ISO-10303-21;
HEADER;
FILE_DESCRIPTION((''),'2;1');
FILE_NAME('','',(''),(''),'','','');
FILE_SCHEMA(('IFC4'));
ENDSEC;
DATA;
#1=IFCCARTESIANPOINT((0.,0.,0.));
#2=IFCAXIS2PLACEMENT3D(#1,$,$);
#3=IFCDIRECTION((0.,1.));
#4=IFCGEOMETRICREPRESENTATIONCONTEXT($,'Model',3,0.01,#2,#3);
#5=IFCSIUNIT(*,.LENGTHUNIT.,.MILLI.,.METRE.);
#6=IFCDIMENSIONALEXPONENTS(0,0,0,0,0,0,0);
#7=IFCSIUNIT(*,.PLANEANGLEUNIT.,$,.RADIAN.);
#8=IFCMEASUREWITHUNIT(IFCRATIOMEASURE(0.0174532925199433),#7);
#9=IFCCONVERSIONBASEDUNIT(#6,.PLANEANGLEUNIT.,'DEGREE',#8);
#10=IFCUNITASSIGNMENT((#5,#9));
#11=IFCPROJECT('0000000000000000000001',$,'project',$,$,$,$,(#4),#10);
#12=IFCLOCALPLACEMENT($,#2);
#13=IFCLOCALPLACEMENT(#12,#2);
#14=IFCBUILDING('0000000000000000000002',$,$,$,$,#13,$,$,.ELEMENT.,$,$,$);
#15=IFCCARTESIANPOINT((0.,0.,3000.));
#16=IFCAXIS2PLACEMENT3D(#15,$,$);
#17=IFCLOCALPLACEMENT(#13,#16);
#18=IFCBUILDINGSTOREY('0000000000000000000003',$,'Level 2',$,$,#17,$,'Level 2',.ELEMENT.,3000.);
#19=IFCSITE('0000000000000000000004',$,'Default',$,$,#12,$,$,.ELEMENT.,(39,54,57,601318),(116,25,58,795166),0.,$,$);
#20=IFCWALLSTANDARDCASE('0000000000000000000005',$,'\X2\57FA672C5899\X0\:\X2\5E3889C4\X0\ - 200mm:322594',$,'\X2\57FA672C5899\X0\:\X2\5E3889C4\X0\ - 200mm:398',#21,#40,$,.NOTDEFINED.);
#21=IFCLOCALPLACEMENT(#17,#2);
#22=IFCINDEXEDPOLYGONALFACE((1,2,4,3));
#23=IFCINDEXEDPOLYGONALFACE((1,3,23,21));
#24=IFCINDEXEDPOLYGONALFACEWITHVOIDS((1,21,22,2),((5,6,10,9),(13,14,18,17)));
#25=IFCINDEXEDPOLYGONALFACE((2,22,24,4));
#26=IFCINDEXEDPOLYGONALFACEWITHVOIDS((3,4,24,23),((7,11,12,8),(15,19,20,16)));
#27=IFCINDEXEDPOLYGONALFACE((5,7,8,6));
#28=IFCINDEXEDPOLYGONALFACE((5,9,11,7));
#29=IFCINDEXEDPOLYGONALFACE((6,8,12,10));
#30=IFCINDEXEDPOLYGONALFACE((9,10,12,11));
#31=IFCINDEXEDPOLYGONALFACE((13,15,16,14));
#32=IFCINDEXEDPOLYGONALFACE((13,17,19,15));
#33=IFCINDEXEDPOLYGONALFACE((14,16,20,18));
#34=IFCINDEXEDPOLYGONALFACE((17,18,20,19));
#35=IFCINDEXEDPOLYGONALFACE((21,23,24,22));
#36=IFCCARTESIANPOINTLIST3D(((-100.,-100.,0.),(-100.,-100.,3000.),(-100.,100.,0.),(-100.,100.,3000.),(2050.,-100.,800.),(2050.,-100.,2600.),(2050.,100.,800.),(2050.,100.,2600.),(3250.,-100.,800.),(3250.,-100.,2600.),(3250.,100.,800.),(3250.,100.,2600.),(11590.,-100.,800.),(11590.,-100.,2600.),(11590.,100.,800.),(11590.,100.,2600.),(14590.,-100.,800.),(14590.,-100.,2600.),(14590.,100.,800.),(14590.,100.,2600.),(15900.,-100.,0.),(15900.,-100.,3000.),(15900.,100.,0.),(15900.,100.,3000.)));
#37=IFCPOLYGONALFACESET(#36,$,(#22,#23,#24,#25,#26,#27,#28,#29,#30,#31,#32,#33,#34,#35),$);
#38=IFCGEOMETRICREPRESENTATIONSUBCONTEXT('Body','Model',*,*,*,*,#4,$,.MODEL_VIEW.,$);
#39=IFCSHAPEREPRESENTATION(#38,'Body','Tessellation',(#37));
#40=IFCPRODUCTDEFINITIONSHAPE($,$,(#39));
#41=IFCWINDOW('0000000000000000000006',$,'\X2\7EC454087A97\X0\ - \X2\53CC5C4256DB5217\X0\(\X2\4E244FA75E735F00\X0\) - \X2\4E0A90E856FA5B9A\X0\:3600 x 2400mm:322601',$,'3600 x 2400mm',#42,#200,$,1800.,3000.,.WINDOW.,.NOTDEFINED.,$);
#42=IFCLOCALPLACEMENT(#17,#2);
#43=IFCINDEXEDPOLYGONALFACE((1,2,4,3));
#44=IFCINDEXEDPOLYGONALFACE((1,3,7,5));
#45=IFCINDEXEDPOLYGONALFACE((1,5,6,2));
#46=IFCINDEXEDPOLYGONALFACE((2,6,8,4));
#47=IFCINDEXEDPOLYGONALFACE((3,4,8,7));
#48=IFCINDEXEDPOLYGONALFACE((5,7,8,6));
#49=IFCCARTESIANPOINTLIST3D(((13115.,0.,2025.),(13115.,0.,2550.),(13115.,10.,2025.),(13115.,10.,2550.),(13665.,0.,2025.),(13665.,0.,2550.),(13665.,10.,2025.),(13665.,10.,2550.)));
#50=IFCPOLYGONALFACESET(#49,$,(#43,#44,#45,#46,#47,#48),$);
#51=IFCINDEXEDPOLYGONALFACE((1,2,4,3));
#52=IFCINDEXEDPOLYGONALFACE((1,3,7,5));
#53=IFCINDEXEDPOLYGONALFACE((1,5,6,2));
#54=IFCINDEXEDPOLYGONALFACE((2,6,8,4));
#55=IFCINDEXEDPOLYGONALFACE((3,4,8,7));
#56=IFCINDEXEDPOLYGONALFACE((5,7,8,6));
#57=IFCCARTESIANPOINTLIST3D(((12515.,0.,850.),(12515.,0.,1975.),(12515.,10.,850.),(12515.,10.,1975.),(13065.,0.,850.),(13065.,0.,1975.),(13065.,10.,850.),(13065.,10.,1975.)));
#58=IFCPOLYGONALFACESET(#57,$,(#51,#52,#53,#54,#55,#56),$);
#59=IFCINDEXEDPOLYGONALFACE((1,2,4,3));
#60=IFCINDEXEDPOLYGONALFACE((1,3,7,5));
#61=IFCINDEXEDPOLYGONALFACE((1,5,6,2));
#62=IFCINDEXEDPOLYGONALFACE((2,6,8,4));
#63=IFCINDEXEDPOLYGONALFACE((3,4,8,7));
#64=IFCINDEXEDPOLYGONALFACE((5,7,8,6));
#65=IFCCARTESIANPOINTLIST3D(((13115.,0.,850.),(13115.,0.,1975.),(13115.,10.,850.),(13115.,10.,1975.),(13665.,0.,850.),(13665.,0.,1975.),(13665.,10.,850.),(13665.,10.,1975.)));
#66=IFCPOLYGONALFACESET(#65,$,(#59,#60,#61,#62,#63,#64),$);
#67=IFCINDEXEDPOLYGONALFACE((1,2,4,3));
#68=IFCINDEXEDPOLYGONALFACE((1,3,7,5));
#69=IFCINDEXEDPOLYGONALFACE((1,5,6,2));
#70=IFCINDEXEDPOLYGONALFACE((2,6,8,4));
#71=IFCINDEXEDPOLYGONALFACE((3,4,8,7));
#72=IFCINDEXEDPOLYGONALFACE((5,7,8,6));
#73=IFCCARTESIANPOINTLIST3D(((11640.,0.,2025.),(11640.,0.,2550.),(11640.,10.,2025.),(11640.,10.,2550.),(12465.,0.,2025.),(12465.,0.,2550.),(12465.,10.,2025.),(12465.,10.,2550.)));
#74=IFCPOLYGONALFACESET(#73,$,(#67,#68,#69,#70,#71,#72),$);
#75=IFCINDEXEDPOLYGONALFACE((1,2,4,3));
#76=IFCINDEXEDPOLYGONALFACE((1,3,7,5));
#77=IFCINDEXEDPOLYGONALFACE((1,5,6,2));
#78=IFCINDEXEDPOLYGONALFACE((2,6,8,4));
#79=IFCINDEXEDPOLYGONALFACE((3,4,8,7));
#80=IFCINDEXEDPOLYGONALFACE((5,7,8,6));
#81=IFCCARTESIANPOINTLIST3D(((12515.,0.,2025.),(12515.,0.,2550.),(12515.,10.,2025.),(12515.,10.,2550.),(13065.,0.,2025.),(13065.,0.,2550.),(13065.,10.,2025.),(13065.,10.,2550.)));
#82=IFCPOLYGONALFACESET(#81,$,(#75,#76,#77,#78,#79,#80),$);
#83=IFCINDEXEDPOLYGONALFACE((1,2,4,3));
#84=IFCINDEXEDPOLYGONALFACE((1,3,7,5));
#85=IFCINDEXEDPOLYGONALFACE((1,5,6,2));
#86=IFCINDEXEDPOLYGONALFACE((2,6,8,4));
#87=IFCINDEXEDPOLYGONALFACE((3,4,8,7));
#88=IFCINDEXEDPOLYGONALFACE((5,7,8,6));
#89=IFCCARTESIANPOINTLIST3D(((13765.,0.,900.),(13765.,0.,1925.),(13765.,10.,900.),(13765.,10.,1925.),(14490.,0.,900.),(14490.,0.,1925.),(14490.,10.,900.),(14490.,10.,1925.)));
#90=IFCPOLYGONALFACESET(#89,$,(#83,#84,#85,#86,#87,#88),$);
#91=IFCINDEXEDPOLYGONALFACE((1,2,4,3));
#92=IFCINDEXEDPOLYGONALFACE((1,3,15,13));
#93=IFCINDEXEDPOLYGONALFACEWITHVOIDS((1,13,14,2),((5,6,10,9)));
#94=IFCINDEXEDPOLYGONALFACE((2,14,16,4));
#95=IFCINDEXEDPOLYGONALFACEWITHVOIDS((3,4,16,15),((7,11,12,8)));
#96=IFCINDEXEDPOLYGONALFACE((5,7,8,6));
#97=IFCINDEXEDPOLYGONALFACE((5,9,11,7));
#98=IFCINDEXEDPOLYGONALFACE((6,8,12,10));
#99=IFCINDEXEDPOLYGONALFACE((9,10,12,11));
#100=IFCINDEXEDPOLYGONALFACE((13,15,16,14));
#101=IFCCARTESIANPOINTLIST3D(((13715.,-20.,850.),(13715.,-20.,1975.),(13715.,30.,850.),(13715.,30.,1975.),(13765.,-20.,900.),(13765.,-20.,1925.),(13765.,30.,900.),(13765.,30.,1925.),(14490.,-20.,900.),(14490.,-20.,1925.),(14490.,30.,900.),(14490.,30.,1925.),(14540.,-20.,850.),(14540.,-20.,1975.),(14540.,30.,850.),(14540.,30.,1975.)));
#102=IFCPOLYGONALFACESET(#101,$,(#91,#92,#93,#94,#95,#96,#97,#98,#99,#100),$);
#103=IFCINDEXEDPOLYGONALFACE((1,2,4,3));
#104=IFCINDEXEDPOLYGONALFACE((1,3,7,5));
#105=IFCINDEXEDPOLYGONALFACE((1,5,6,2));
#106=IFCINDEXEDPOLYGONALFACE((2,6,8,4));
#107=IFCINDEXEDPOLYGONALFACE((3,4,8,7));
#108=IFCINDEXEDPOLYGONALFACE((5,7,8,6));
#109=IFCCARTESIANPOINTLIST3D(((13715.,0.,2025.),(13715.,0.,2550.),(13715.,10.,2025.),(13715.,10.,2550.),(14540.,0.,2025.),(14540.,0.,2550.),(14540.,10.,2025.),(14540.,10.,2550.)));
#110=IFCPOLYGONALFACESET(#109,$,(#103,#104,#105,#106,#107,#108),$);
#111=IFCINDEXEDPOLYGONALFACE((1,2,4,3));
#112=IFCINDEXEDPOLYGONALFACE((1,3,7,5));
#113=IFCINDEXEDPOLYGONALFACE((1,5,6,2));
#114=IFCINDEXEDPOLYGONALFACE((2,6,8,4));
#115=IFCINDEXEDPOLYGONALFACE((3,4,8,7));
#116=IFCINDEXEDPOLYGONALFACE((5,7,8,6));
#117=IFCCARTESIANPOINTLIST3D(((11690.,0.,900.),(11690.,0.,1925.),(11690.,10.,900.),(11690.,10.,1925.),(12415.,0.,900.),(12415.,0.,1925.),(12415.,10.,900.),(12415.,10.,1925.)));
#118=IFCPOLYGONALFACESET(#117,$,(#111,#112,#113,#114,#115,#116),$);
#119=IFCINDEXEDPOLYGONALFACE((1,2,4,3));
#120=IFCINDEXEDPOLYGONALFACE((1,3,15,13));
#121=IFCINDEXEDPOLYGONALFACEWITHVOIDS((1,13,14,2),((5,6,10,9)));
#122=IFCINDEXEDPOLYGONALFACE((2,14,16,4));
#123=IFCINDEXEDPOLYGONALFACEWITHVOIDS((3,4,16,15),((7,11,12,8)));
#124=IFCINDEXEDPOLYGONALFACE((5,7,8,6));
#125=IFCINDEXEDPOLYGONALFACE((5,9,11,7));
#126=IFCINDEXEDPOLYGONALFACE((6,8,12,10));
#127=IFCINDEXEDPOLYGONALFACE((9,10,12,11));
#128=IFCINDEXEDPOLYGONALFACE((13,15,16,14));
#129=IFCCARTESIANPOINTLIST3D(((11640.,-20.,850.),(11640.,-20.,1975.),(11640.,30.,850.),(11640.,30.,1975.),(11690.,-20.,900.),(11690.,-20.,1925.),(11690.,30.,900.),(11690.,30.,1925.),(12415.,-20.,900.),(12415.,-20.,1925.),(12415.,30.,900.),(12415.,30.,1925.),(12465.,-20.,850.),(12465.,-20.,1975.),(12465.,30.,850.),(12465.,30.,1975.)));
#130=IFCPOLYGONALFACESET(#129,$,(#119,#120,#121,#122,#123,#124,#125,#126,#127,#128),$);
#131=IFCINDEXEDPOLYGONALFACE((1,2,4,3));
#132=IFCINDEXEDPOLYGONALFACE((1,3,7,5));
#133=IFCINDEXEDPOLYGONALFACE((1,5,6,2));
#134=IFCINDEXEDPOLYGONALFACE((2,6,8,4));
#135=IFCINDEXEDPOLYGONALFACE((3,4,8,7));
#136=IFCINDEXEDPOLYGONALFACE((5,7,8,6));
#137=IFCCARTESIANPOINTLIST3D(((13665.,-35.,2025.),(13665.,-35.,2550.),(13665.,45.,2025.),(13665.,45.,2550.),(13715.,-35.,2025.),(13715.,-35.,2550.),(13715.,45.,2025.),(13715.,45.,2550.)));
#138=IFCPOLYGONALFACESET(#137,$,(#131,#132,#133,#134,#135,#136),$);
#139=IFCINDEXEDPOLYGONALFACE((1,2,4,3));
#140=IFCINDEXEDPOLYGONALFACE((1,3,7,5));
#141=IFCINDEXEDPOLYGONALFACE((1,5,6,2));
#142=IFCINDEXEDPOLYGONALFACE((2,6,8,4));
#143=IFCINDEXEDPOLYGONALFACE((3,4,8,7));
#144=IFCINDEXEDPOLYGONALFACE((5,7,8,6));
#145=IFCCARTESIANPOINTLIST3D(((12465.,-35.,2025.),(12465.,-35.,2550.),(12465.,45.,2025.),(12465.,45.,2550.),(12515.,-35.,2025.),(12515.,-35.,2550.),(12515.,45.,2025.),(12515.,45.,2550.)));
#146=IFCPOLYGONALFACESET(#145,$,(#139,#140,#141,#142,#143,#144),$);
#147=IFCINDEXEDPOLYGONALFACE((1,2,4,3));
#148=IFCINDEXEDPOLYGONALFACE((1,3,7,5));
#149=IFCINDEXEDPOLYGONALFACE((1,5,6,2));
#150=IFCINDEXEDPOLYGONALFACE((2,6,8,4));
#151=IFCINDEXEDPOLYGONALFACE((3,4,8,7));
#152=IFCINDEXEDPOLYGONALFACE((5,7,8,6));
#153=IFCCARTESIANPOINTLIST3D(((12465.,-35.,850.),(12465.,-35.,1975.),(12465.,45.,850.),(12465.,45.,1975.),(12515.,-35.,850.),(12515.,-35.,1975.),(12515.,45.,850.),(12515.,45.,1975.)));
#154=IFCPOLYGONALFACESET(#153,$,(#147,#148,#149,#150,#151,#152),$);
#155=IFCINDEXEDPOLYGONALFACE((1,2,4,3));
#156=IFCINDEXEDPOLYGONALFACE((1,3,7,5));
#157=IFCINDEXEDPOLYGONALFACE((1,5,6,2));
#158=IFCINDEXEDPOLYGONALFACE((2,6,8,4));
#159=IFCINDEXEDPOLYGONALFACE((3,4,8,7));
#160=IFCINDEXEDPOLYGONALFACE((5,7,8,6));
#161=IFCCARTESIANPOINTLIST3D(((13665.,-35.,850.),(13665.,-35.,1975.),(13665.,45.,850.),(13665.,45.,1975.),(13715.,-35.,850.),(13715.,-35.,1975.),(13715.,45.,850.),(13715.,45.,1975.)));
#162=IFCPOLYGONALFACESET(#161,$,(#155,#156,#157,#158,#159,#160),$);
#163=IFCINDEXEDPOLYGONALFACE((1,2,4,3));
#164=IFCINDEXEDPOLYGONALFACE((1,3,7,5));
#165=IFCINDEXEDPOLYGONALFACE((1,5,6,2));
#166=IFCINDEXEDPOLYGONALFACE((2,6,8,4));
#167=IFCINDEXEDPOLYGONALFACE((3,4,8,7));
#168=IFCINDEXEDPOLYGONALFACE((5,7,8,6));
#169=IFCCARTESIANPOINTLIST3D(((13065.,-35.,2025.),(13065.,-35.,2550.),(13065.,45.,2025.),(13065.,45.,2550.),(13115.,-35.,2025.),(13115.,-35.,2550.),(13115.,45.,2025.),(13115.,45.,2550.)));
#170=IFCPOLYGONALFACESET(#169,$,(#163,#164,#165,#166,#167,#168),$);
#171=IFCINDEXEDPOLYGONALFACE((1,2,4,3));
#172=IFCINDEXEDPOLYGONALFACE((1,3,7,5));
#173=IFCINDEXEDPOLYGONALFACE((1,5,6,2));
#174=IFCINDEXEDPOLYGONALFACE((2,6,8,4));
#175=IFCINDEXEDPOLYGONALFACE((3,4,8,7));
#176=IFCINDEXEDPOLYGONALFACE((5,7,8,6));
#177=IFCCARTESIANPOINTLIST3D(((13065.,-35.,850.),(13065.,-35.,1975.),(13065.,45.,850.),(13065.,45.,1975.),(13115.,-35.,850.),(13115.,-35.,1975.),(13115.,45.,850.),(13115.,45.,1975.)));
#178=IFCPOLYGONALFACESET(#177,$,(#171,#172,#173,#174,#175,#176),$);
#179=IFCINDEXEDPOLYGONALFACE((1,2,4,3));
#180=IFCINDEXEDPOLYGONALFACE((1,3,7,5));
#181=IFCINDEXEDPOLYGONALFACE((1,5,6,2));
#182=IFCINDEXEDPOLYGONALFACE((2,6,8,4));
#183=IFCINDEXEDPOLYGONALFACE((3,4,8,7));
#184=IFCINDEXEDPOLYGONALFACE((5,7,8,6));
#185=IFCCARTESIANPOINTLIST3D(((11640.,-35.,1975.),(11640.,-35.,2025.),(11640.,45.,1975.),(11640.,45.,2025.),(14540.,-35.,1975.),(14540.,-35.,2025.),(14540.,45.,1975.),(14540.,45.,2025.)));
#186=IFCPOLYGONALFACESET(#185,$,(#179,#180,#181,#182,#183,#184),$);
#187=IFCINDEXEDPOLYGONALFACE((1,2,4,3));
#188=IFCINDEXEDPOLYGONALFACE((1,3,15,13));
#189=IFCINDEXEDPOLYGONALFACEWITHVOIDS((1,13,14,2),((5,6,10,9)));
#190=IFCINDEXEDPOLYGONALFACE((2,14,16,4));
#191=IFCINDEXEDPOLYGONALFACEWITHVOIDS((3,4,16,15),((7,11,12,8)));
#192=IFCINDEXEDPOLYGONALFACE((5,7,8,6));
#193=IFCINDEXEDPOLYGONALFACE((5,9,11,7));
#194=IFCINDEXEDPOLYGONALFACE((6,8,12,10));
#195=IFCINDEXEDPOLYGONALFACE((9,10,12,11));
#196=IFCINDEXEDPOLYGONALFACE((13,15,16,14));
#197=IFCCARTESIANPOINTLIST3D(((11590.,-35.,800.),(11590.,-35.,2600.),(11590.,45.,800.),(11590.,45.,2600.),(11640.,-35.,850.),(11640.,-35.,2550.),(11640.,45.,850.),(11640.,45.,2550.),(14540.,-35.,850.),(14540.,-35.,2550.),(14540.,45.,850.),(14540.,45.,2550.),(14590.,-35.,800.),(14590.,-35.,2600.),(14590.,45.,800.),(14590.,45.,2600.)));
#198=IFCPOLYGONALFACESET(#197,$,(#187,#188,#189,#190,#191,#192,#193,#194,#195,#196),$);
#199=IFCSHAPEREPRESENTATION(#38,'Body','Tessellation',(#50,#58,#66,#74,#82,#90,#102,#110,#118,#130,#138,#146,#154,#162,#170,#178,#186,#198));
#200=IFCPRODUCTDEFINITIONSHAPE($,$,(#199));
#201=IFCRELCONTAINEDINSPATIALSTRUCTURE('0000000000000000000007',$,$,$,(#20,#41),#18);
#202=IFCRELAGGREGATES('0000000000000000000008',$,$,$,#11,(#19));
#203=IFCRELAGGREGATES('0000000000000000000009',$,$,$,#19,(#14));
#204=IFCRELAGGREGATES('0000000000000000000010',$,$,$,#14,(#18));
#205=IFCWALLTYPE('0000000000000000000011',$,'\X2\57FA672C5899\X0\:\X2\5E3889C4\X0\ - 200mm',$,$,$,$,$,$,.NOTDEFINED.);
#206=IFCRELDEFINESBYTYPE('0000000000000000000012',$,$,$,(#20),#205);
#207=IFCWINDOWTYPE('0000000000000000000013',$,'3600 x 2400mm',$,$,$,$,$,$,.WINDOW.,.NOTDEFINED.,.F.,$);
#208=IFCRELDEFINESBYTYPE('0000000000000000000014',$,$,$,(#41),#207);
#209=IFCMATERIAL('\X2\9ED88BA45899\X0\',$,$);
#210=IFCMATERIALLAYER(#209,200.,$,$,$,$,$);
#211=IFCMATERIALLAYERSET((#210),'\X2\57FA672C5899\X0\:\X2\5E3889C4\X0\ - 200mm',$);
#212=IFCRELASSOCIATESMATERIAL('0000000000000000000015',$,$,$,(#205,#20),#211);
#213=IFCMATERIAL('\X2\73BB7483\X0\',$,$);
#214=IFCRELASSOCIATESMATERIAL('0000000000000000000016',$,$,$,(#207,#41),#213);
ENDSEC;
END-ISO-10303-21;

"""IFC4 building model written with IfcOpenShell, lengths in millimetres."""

from ifc_helpers import new_model, entity, si_unit, converted_unit, direction, frame, frame_2d, origin, origin_2d_with_axis, place, context, subcontext, project, spatial, polyline, rectangle, outline, extrude, source, transform, mapped, material, layer, layer_set, layer_usage, type_object, type_shapes, element, fill, save


model = new_model("IFC4")

# Units and contexts
model_context_1 = context("Model", 3, precision=0.01, world=origin(), true_north=direction((0.0, 1.0)))
body_context_1 = subcontext(model_context_1, "Body", "Model", "MODEL_VIEW")
ifc_project = project(units=[si_unit("LENGTHUNIT", "METRE", prefix="MILLI"), converted_unit("PLANEANGLEUNIT", "DEGREE", entity("IfcRatioMeasure", 0.0174532925199433), si_unit("PLANEANGLEUNIT", "RADIAN"), dimensions=[0, 0, 0, 0, 0, 0, 0])], contexts=[model_context_1])

# Site, building, storey
site_placement = place(None, origin())
site = spatial("IfcSite", under=ifc_project, at=site_placement, Name="Default", CompositionType="ELEMENT", RefLatitude=(39, 54, 57, 601318), RefLongitude=(116, 25, 58, 795166), RefElevation=0.0)
building_placement = place(site_placement, origin())
building = spatial("IfcBuilding", under=site, at=building_placement, CompositionType="ELEMENT")
storey_placement = place(building_placement, frame((0.0, 0.0, 3000.0)))
storey = spatial("IfcBuildingStorey", under=building, at=storey_placement, Name="Level 2", LongName="Level 2", CompositionType="ELEMENT", Elevation=3000.0)

# Shared definitions
ifc_material_1 = material(Name="默认墙")
ifc_layer = layer(ifc_material_1, 200.0)
ifc_layer_set = layer_set([ifc_layer], Name="基本墙:常规 - 200mm")
wall_type = type_object("IfcWallType", Name="基本墙:常规 - 200mm", PredefinedType="NOTDEFINED", material=ifc_layer_set)

# Shared definitions
ifc_material_2 = material(Name="玻璃")

# Wall, openings, window
ifc_layer_usage_1 = layer_usage(ifc_layer_set, "AXIS2", "NEGATIVE", 100.0)
wall_1_placement = place(storey_placement, frame((15900.0, 0.0, 0.0), z_axis=(0.0, 0.0, 1.0), x_axis=(-1.0, 0.0, 0.0)))
wall_1 = element("IfcWallStandardCase", 1, at=wall_1_placement, inside=storey, type_object=wall_type, material=ifc_layer_usage_1, Name="基本墙:常规 - 200mm:322594", ObjectType="基本墙:常规 - 200mm:398", PredefinedType="NOTDEFINED", context=body_context_1, shape_type="SweptSolid", body=[
    extrude(rectangle(XDim=16000.0, YDim=200.0, at=frame_2d((8000.0, 0.0), x_axis=(-1.0, 0.0))), origin(), (0.0, 0.0, 1.0), 3000.0),
])
opening_1_placement = place(wall_1_placement, frame((12650.0, -100.0, 800.0)))
element("IfcOpeningElement", 2, at=opening_1_placement, cuts=wall_1, ObjectType="Opening", PredefinedType="OPENING", context=body_context_1, shape_type="SweptSolid", body=[
    extrude(rectangle(XDim=1800.0, YDim=1200.0, at=frame_2d((900.0, 600.0), x_axis=(1.0, 0.0))), frame((0.0, 0.0, 0.0), z_axis=(0.0, 1.0, 0.0), x_axis=(0.0, 0.0, 1.0)), (0.0, 0.0, 1.0), 200.0),
])
opening_2_placement = place(wall_1_placement, frame((1310.0, -100.0, 800.0)))
opening_2 = element("IfcOpeningElement", 3, at=opening_2_placement, cuts=wall_1, ObjectType="Opening", PredefinedType="OPENING", context=body_context_1, shape_type="SweptSolid", body=[
    extrude(rectangle(XDim=1800.0, YDim=3000.0, at=frame_2d((900.0, 1500.0), x_axis=(1.0, 0.0))), frame((0.0, 0.0, 0.0), z_axis=(0.0, 1.0, 0.0), x_axis=(0.0, 0.0, 1.0)), (0.0, 0.0, 1.0), 200.0),
])
window_type_1 = type_object("IfcWindowType", Name="3600 x 2400mm", ParameterTakesPrecedence=False, PartitioningType="NOTDEFINED", PredefinedType="WINDOW", material=ifc_material_2)
shared_shape_1 = source(origin(), body_context_1, "Body", "SweptSolid", [
    extrude(rectangle(XDim=10.0, YDim=550.0, at=origin_2d_with_axis()), frame((1200.0, 95.0, 1225.0), z_axis=(0.0, 0.0, 1.0), x_axis=(0.0, 1.0, 0.0)), (0.0, 0.0, 1.0), 525.0),
    extrude(rectangle(XDim=10.0, YDim=550.0, at=origin_2d_with_axis()), frame((1800.0, 95.0, 50.0), z_axis=(0.0, 0.0, 1.0), x_axis=(0.0, 1.0, 0.0)), (0.0, 0.0, 1.0), 1125.0),
    extrude(rectangle(XDim=10.0, YDim=550.0, at=origin_2d_with_axis()), frame((1200.0, 95.0, 50.0), z_axis=(0.0, 0.0, 1.0), x_axis=(0.0, 1.0, 0.0)), (0.0, 0.0, 1.0), 1125.0),
    extrude(rectangle(XDim=10.0, YDim=825.0, at=frame_2d((0.0, 0.0), x_axis=(1.0, 0.0))), frame((2537.5, 95.0, 1225.0), z_axis=(0.0, 0.0, 1.0), x_axis=(0.0, 1.0, 0.0)), (0.0, 0.0, 1.0), 525.0),
    extrude(rectangle(XDim=10.0, YDim=550.0, at=frame_2d((0.0, 0.0), x_axis=(1.0, 0.0))), frame((1800.0, 95.0, 1225.0), z_axis=(0.0, 0.0, 1.0), x_axis=(0.0, 1.0, 0.0)), (0.0, 0.0, 1.0), 525.0),
    extrude(rectangle(XDim=10.0, YDim=725.0, at=frame_2d((0.0, 0.0), x_axis=(1.0, 0.0))), frame((462.5, 95.0, 100.0), z_axis=(0.0, 0.0, 1.0), x_axis=(0.0, 1.0, 0.0)), (0.0, 0.0, 1.0), 1025.0),
    extrude(outline(polyline([(-562.5, -412.5), (562.5, -412.5), (562.5, 412.5), (-562.5, 412.5), (-562.5, -412.5)]), holes=[polyline([(512.5, -362.5), (-512.5, -362.5), (-512.5, 362.5), (512.5, 362.5), (512.5, -362.5)])]), frame((462.5, 70.0, 612.5), z_axis=(0.0, 1.0, 0.0), x_axis=(0.0, 0.0, -1.0)), (0.0, 0.0, 1.0), 50.0),
    extrude(rectangle(XDim=10.0, YDim=825.0, at=origin_2d_with_axis()), frame((462.5, 95.0, 1225.0), z_axis=(0.0, 0.0, 1.0), x_axis=(0.0, 1.0, 0.0)), (0.0, 0.0, 1.0), 525.0),
    extrude(rectangle(XDim=10.0, YDim=725.0, at=frame_2d((0.0, 0.0), x_axis=(1.0, 0.0))), frame((2537.5, 95.0, 100.0), z_axis=(0.0, 0.0, 1.0), x_axis=(0.0, 1.0, 0.0)), (0.0, 0.0, 1.0), 1025.0),
    extrude(outline(polyline([(-562.5, -412.5), (562.5, -412.5), (562.5, 412.5), (-562.5, 412.5), (-562.5, -412.5)]), holes=[polyline([(512.5, -362.5), (-512.5, -362.5), (-512.5, 362.5), (512.5, 362.5), (512.5, -362.5)])]), frame((2537.5, 70.0, 612.5), z_axis=(0.0, 1.0, 0.0), x_axis=(0.0, 0.0, -1.0)), (0.0, 0.0, 1.0), 50.0),
    extrude(rectangle(XDim=80.0, YDim=50.0, at=origin_2d_with_axis()), frame((900.0, 95.0, 1225.0), z_axis=(0.0, 0.0, 1.0), x_axis=(0.0, -1.0, 0.0)), (0.0, 0.0, 1.0), 525.0),
    extrude(rectangle(XDim=80.0, YDim=50.0, at=frame_2d((0.0, 0.0), x_axis=(1.0, 0.0))), frame((2100.0, 95.0, 1225.0), z_axis=(0.0, 0.0, 1.0), x_axis=(0.0, -1.0, 0.0)), (0.0, 0.0, 1.0), 525.0),
    extrude(rectangle(XDim=80.0, YDim=50.0, at=origin_2d_with_axis()), frame((2100.0, 95.0, 50.0), z_axis=(0.0, 0.0, 1.0), x_axis=(0.0, -1.0, 0.0)), (0.0, 0.0, 1.0), 1125.0),
    extrude(rectangle(XDim=80.0, YDim=50.0, at=origin_2d_with_axis()), frame((900.0, 95.0, 50.0), z_axis=(0.0, 0.0, 1.0), x_axis=(0.0, -1.0, 0.0)), (0.0, 0.0, 1.0), 1125.0),
    extrude(rectangle(XDim=80.0, YDim=50.0, at=frame_2d((0.0, 0.0), x_axis=(1.0, 0.0))), frame((1500.0, 95.0, 1225.0), z_axis=(0.0, 0.0, 1.0), x_axis=(0.0, -1.0, 0.0)), (0.0, 0.0, 1.0), 525.0),
    extrude(rectangle(XDim=80.0, YDim=50.0, at=origin_2d_with_axis()), frame((1500.0, 95.0, 50.0), z_axis=(0.0, 0.0, 1.0), x_axis=(0.0, -1.0, 0.0)), (0.0, 0.0, 1.0), 1125.0),
    extrude(rectangle(XDim=80.0, YDim=2900.0, at=frame_2d((0.0, 0.0), x_axis=(1.0, 0.0))), frame((1500.0, 95.0, 1175.0), z_axis=(0.0, 0.0, 1.0), x_axis=(0.0, -1.0, 0.0)), (0.0, 0.0, 1.0), 50.0),
    extrude(outline(polyline([(-1500.0, -900.0), (1500.0, -900.0), (1500.0, 900.0), (-1500.0, 900.0), (-1500.0, -900.0)]), holes=[polyline([(1450.0, -850.0), (-1450.0, -850.0), (-1450.0, 850.0), (1450.0, 850.0), (1450.0, -850.0)])]), frame((1500.0, 55.0, 900.0), z_axis=(0.0, 1.0, 0.0), x_axis=(1.0, 0.0, 0.0)), (0.0, 0.0, 1.0), 80.0),
])
type_shapes(window_type_1, [shared_shape_1])
window_1_placement = place(opening_2_placement, origin())
window_1 = element("IfcWindow", 4, at=window_1_placement, inside=storey, type_object=window_type_1, material=ifc_material_2, Name="组合窗 - 双层四列(两侧平开) - 上部固定:3600 x 2400mm:322601", ObjectType="3600 x 2400mm", OverallHeight=1800.0, OverallWidth=3000.0, PartitioningType="NOTDEFINED", PredefinedType="WINDOW", context=body_context_1, shape_type="MappedRepresentation", body=[
    mapped(shared_shape_1, transform((0.0, 0.0, 0.0), scale=1.0)),
])
fill(opening_2, window_1)

save(model, "model.ifc")
